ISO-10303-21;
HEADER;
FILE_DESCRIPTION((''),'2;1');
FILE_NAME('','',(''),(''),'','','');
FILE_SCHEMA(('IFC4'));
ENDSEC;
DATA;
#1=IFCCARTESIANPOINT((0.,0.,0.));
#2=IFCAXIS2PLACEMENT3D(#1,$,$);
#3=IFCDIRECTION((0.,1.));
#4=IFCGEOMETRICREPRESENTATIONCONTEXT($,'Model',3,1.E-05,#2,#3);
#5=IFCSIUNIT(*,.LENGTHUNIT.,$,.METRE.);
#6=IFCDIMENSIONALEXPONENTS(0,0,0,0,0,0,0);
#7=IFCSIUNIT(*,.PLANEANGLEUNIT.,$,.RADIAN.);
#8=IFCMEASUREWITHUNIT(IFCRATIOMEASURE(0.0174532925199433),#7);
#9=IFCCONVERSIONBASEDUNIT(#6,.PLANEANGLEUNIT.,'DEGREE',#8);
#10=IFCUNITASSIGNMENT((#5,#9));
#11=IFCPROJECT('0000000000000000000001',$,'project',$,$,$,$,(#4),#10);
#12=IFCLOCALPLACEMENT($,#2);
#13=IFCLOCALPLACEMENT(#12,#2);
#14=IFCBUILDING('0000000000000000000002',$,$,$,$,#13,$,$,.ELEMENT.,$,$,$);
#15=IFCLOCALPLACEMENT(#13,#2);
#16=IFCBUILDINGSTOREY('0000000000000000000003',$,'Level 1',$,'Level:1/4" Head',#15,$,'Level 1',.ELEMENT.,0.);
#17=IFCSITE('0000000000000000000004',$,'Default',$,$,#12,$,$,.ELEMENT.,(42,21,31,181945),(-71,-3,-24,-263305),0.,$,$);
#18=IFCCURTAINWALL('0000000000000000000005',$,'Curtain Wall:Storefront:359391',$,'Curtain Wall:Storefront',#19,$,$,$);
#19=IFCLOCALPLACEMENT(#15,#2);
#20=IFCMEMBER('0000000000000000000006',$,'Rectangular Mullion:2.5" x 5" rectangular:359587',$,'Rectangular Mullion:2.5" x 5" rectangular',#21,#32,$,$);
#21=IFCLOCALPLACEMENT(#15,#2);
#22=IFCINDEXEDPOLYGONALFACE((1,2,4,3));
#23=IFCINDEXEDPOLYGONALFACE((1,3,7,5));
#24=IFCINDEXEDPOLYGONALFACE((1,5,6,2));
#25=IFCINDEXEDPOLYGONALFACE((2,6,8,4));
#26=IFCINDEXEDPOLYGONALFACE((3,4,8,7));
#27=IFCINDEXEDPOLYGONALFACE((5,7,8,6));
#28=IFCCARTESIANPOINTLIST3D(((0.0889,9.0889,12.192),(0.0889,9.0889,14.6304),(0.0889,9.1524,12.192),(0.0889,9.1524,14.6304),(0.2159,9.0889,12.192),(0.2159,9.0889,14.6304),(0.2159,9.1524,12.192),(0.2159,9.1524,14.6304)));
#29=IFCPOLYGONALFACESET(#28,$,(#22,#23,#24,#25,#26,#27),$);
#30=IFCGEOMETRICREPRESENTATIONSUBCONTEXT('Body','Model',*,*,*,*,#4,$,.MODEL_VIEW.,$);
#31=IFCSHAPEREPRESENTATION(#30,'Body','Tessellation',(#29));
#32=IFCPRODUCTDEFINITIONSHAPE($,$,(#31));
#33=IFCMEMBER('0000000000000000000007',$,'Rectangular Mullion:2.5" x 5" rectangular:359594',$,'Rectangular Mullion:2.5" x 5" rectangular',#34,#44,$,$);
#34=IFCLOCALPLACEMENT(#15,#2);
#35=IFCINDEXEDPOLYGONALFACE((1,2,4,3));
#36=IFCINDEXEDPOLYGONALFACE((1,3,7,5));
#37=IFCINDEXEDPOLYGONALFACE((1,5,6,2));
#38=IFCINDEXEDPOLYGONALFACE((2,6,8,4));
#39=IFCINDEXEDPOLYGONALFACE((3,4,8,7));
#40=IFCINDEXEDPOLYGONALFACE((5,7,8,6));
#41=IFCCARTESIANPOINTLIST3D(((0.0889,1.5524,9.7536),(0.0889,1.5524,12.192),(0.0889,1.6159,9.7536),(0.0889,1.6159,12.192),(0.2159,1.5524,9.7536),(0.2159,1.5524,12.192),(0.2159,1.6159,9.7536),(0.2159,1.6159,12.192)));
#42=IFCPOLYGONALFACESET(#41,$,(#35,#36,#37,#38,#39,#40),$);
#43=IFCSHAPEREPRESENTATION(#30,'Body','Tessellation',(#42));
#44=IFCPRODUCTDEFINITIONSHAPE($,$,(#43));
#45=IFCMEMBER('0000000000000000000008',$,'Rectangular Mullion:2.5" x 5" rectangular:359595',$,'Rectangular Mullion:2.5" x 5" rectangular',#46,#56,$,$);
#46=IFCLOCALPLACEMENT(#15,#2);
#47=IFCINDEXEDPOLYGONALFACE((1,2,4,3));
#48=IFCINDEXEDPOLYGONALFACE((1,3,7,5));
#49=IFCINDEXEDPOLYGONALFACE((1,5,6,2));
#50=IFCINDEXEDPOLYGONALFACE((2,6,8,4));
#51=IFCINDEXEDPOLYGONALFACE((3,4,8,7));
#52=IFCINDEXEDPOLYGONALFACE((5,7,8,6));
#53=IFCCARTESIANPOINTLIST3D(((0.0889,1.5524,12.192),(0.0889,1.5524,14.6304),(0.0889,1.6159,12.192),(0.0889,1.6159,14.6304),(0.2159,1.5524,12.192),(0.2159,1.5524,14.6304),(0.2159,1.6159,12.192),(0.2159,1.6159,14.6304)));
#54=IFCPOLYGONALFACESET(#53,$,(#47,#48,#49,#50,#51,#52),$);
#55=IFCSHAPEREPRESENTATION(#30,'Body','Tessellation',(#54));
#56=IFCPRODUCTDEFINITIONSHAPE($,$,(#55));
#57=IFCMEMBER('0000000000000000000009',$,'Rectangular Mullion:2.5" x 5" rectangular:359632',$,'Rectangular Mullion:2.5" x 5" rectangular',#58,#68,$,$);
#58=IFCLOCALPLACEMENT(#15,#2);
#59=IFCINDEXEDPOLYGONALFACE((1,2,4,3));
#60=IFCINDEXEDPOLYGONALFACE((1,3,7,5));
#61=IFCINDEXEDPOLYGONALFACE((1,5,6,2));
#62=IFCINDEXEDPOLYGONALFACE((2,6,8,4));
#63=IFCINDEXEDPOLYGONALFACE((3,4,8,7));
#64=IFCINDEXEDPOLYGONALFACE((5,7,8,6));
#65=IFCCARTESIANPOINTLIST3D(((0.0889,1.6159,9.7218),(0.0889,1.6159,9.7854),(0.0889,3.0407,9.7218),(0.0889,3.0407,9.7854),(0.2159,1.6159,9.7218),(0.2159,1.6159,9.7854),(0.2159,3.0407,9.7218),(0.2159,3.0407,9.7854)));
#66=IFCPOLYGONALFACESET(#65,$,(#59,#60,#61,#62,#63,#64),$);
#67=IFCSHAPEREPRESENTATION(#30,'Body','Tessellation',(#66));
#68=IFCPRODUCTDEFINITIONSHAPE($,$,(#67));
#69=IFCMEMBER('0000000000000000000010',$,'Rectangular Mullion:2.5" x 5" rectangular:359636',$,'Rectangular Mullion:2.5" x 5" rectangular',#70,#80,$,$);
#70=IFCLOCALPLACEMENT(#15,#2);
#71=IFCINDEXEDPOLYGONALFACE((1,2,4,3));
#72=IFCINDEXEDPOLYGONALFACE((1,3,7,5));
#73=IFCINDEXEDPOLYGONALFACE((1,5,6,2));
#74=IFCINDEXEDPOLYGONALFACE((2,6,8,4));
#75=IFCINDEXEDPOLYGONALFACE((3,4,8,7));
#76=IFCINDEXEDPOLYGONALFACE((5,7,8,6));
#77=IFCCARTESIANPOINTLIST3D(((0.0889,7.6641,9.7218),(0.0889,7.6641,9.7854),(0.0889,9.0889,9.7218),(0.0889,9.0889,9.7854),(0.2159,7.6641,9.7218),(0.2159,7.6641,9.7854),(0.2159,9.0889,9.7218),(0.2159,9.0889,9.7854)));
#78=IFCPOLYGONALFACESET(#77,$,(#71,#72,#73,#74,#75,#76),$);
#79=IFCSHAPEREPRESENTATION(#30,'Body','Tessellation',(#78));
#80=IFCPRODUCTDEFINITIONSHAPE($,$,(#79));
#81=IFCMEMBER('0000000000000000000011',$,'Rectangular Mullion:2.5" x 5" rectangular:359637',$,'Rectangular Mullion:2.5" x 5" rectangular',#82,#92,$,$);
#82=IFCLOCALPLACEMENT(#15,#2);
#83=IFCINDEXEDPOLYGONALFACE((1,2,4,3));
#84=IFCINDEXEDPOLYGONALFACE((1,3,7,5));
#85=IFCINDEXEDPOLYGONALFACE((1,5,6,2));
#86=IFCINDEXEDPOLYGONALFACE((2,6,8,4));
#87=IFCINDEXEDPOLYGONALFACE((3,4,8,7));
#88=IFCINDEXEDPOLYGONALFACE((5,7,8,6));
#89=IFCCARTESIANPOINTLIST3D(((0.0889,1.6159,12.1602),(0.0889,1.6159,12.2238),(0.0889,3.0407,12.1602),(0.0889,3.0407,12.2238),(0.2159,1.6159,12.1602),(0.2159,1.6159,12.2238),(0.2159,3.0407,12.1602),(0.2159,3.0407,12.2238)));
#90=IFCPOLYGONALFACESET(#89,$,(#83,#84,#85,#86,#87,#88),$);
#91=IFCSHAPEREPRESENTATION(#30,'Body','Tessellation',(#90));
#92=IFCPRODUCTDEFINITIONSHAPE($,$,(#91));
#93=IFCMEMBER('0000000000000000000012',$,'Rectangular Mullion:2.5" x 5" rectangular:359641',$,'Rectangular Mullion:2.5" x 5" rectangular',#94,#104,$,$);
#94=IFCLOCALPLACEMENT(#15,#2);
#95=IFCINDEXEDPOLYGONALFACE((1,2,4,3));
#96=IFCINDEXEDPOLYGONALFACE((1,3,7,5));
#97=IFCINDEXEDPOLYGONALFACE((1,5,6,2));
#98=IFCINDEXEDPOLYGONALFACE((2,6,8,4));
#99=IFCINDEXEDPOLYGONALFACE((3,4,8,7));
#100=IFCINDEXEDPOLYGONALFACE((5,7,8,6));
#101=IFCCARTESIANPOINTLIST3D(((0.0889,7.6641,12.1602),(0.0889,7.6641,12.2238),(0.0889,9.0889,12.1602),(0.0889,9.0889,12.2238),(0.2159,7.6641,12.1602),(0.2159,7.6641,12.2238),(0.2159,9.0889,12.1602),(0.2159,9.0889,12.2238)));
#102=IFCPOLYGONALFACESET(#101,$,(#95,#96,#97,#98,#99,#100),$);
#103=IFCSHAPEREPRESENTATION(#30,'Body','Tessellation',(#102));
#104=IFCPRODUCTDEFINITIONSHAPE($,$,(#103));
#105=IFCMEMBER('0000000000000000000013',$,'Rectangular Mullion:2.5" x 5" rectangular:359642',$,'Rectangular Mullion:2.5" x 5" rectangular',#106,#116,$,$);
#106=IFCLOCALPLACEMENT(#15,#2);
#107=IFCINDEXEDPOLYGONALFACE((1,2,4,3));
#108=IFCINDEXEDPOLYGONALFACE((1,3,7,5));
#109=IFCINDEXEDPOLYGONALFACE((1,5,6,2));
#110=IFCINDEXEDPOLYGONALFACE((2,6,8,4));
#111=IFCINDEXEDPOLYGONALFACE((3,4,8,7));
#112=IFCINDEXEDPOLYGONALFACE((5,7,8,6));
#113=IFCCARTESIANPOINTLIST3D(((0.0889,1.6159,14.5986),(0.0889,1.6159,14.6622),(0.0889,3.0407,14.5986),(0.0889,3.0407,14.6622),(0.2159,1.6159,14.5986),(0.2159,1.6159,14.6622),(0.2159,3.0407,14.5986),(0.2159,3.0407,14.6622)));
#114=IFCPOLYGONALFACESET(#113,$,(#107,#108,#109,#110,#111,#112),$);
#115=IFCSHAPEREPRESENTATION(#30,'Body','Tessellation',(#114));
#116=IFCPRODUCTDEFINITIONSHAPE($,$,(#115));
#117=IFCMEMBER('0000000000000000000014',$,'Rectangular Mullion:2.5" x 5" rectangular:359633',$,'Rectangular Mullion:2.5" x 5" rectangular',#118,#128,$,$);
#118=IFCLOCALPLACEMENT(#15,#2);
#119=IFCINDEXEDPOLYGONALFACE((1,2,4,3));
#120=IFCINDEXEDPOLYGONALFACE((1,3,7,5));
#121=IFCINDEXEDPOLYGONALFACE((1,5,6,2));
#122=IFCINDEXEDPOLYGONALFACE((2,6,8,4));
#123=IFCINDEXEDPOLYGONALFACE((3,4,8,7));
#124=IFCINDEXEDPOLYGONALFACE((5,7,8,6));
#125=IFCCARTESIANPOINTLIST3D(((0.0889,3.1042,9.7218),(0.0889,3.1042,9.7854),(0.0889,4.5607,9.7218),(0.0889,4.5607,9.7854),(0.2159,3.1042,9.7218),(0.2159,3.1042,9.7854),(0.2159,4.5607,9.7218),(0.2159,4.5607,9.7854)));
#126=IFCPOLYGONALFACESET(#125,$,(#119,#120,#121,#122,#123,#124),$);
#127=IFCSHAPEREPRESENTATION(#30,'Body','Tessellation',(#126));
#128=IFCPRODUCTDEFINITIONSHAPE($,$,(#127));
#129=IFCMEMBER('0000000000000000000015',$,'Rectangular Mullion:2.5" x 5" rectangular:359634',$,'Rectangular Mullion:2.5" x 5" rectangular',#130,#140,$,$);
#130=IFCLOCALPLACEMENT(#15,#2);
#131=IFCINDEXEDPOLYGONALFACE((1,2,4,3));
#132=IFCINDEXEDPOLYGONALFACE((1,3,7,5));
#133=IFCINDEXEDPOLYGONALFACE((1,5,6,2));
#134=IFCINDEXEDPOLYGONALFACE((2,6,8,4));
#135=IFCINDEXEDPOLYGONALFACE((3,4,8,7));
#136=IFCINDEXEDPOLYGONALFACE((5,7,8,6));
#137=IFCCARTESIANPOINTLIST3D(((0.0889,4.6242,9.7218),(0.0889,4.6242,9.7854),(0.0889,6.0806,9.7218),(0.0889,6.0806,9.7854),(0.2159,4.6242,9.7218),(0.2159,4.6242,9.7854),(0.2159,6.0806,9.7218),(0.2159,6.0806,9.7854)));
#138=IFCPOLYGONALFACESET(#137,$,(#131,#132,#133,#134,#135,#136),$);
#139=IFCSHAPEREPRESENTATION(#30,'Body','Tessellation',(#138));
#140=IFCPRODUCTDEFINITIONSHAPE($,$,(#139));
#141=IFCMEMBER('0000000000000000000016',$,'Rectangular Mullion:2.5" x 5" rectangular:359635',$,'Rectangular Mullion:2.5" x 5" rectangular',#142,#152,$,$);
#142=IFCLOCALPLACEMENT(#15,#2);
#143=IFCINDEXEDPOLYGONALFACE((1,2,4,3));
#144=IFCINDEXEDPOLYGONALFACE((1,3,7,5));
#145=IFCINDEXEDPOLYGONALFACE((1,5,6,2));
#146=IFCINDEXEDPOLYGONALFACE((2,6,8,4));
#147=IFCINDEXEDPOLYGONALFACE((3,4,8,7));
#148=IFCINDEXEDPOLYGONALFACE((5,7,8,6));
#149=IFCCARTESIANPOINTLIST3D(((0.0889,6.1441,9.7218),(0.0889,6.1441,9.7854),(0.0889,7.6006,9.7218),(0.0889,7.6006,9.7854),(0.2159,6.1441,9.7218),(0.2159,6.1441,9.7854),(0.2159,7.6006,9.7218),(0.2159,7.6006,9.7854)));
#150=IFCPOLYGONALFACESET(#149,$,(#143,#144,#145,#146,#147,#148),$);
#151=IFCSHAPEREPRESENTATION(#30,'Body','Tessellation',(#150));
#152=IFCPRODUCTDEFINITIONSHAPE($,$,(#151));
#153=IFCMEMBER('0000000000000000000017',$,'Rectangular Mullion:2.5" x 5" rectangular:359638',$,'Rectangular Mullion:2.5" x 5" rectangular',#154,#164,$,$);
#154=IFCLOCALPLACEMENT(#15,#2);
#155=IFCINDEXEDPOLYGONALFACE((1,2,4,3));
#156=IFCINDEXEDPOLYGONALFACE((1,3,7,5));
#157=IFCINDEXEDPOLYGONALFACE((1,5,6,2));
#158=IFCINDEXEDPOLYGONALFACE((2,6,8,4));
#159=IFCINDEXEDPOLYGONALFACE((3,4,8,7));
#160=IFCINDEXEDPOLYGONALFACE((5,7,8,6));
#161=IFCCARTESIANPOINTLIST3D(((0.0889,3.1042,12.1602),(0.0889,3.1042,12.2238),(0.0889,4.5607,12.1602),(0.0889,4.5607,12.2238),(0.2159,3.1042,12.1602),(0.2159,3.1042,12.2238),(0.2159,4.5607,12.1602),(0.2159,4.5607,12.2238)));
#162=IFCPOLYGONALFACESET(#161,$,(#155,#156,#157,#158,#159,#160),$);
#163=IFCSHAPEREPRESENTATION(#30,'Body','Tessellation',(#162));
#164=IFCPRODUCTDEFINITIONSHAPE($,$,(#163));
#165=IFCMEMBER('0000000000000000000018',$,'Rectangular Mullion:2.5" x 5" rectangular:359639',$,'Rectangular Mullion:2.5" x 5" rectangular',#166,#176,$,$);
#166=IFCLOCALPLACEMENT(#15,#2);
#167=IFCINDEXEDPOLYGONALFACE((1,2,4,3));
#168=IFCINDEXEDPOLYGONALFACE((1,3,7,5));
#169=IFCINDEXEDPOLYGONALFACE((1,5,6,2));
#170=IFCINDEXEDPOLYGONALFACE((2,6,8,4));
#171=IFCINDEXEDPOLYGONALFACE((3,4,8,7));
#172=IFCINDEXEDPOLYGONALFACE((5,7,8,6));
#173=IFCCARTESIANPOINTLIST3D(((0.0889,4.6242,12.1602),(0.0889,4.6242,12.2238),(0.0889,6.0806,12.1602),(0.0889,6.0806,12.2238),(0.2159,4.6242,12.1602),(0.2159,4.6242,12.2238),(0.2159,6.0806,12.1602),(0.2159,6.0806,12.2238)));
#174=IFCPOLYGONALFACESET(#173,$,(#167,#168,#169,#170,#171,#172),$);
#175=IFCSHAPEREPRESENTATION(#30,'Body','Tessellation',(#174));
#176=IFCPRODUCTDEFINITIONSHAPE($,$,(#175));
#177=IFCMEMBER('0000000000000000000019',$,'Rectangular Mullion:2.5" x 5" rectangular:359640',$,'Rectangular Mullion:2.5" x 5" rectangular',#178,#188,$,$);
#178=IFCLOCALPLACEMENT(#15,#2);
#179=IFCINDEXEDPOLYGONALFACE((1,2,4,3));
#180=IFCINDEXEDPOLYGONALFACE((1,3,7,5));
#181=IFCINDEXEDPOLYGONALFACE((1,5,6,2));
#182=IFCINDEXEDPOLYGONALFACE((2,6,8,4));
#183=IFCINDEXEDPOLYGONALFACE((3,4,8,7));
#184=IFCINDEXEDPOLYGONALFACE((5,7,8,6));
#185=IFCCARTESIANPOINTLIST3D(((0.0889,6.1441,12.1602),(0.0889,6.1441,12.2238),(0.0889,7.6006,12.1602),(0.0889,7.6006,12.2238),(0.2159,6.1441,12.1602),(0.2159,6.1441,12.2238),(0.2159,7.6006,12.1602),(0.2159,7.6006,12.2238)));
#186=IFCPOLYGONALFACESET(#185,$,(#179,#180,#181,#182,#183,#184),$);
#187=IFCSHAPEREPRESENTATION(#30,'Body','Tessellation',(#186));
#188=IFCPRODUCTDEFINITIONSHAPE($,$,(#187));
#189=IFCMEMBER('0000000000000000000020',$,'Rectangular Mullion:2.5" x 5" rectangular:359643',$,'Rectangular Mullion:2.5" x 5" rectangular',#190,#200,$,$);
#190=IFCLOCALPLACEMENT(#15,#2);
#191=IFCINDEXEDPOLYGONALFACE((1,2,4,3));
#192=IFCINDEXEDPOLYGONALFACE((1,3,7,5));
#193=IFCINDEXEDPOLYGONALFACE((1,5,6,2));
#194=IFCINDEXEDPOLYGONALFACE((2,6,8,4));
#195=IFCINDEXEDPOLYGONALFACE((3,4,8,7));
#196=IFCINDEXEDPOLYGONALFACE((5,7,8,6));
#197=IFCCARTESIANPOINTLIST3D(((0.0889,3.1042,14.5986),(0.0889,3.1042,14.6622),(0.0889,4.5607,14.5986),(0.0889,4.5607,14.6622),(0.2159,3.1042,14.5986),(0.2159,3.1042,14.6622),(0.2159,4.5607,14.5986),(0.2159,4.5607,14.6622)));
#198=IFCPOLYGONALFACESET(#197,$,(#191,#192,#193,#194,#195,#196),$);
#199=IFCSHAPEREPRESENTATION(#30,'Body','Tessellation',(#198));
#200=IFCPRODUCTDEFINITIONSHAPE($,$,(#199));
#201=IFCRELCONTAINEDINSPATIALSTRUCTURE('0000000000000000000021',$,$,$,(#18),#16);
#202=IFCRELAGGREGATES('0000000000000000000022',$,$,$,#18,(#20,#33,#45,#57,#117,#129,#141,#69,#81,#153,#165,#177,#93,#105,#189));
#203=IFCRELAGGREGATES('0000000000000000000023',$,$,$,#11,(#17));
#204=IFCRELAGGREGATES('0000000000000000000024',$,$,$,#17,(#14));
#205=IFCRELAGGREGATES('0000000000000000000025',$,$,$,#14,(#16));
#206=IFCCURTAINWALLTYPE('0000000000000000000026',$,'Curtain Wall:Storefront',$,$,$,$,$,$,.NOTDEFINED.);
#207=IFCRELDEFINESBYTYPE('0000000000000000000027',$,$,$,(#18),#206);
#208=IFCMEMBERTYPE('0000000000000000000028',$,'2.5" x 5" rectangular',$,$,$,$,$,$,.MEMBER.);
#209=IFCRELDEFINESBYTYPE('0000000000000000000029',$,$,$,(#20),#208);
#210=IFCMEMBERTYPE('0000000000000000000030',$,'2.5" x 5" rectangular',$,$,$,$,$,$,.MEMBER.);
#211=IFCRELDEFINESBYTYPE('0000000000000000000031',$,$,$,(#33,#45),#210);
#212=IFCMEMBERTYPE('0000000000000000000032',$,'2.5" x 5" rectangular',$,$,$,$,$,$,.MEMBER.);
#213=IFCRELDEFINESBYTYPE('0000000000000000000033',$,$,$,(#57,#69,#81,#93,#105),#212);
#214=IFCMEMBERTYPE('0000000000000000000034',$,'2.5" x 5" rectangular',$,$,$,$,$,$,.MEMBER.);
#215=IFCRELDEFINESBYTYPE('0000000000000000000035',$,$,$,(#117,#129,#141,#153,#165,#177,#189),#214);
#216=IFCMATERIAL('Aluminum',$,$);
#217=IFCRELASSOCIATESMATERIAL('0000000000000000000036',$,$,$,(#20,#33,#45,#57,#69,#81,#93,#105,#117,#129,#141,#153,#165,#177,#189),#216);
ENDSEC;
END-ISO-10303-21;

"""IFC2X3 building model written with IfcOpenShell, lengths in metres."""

from ifc_helpers import new_model, entity, si_unit, converted_unit, direction, frame, origin, origin_2d_with_axis, place, context, subcontext, project, spatial, rectangle, extrude, source, transform, mapped, material, type_object, type_shapes, element, aggregate, save


model = new_model("IFC2X3")

# Units and contexts
model_context = context("Model", 3, precision=1e-05, world=origin(), true_north=direction((0.0, 1.0)))
body_context = subcontext(model_context, "Body", "Model", "MODEL_VIEW")
ifc_project = project(units=[si_unit("LENGTHUNIT", "METRE"), converted_unit("PLANEANGLEUNIT", "DEGREE", entity("IfcRatioMeasure", 0.0174532925199433), si_unit("PLANEANGLEUNIT", "RADIAN"), dimensions=[0, 0, 0, 0, 0, 0, 0])], contexts=[model_context])

# Site, building, storey
site_placement = place(None, origin())
site = spatial("IfcSite", under=ifc_project, at=site_placement, Name="Default", CompositionType="ELEMENT", RefLatitude=(42, 21, 31, 181945), RefLongitude=(-71, -3, -24, -263305), RefElevation=0.0)
building_placement = place(site_placement, origin())
building = spatial("IfcBuilding", under=site, at=building_placement, CompositionType="ELEMENT")
storey_placement = place(building_placement, origin())
storey = spatial("IfcBuildingStorey", under=building, at=storey_placement, Name="Level 1", ObjectType="Level:1/4\" Head", LongName="Level 1", CompositionType="ELEMENT", Elevation=0.0)

# Curtain wall, members
curtain_wall_type = type_object("IfcCurtainWallType", Name="Curtain Wall:Storefront", PredefinedType="NOTDEFINED")
curtain_wall_placement = place(storey_placement, origin())
curtain_wall = element("IfcCurtainWall", 1, at=curtain_wall_placement, inside=storey, type_object=curtain_wall_type, Name="Curtain Wall:Storefront:359391", ObjectType="Curtain Wall:Storefront")
ifc_material_1 = material(Name="Aluminum")
member_type_1 = type_object("IfcMemberType", Name="2.5\" x 5\" rectangular", PredefinedType="MEMBER")
shared_shape_1 = source(origin(), body_context, "Body", "SweptSolid", [
    extrude(rectangle(XDim=0.127, YDim=0.0635, at=origin_2d_with_axis()), frame((-0.0318, 0.0, -2.4384), z_axis=(0.0, 0.0, 1.0), x_axis=(0.0, -1.0, 0.0)), (0.0, 0.0, 1.0), 2.4384),
])
type_shapes(member_type_1, [shared_shape_1])
member_1_placement = place(storey_placement, frame((0.1524, 9.1524, 12.192), z_axis=(0.0, 0.0, -1.0), x_axis=(0.0, 1.0, 0.0)))
member_1 = element("IfcMember", 2, at=member_1_placement, type_object=member_type_1, material=ifc_material_1, Name="Rectangular Mullion:2.5\" x 5\" rectangular:359587", ObjectType="Rectangular Mullion:2.5\" x 5\" rectangular", context=body_context, shape_type="MappedRepresentation", body=[
    mapped(shared_shape_1, transform((0.0, 0.0, 0.0), scale=1.0)),
])
member_type_2 = type_object("IfcMemberType", Name="2.5\" x 5\" rectangular", PredefinedType="MEMBER")
shared_shape_2 = source(origin(), body_context, "Body", "SweptSolid", [
    extrude(rectangle(XDim=0.127, YDim=0.0635, at=origin_2d_with_axis()), frame((-0.0318, 0.0, -2.4384), z_axis=(0.0, 0.0, 1.0), x_axis=(0.0, -1.0, 0.0)), (0.0, 0.0, 1.0), 2.4384),
])
type_shapes(member_type_2, [shared_shape_2])
member_2_placement = place(storey_placement, frame((0.1524, 1.5524, 12.192), z_axis=(0.0, 0.0, 1.0), x_axis=(0.0, -1.0, 0.0)))
member_2 = element("IfcMember", 3, at=member_2_placement, type_object=member_type_2, material=ifc_material_1, Name="Rectangular Mullion:2.5\" x 5\" rectangular:359594", ObjectType="Rectangular Mullion:2.5\" x 5\" rectangular", context=body_context, shape_type="MappedRepresentation", body=[
    mapped(shared_shape_2, transform((0.0, 0.0, 0.0), scale=1.0)),
])
member_3_placement = place(storey_placement, frame((0.1524, 1.5524, 14.6304), z_axis=(0.0, 0.0, 1.0), x_axis=(0.0, -1.0, 0.0)))
member_3 = element("IfcMember", 4, at=member_3_placement, type_object=member_type_2, material=ifc_material_1, Name="Rectangular Mullion:2.5\" x 5\" rectangular:359595", ObjectType="Rectangular Mullion:2.5\" x 5\" rectangular", context=body_context, shape_type="MappedRepresentation", body=[
    mapped(shared_shape_2, transform((0.0, 0.0, 0.0), scale=1.0)),
])
member_type_3 = type_object("IfcMemberType", Name="2.5\" x 5\" rectangular", PredefinedType="MEMBER")
shared_shape_3 = source(origin(), body_context, "Body", "SweptSolid", [
    extrude(rectangle(XDim=0.127, YDim=0.0635, at=origin_2d_with_axis()), frame((0.0, 0.0, -1.4248), z_axis=(0.0, 0.0, 1.0), x_axis=(0.0, -1.0, 0.0)), (0.0, 0.0, 1.0), 1.4248),
])
type_shapes(member_type_3, [shared_shape_3])
member_4_placement = place(storey_placement, frame((0.1524, 3.0407, 9.7536), z_axis=(0.0, 1.0, 0.0), x_axis=(0.0, 0.0, 1.0)))
member_4 = element("IfcMember", 5, at=member_4_placement, type_object=member_type_3, material=ifc_material_1, Name="Rectangular Mullion:2.5\" x 5\" rectangular:359632", ObjectType="Rectangular Mullion:2.5\" x 5\" rectangular", context=body_context, shape_type="MappedRepresentation", body=[
    mapped(shared_shape_3, transform((0.0, 0.0, 0.0), scale=1.0)),
])
member_5_placement = place(storey_placement, frame((0.1524, 9.0889, 9.7536), z_axis=(0.0, 1.0, 0.0), x_axis=(0.0, 0.0, 1.0)))
member_5 = element("IfcMember", 6, at=member_5_placement, type_object=member_type_3, material=ifc_material_1, Name="Rectangular Mullion:2.5\" x 5\" rectangular:359636", ObjectType="Rectangular Mullion:2.5\" x 5\" rectangular", context=body_context, shape_type="MappedRepresentation", body=[
    mapped(shared_shape_3, transform((0.0, 0.0, 0.0), scale=1.0)),
])
member_6_placement = place(storey_placement, frame((0.1524, 3.0407, 12.192), z_axis=(0.0, 1.0, 0.0), x_axis=(0.0, 0.0, 1.0)))
member_6 = element("IfcMember", 7, at=member_6_placement, type_object=member_type_3, material=ifc_material_1, Name="Rectangular Mullion:2.5\" x 5\" rectangular:359637", ObjectType="Rectangular Mullion:2.5\" x 5\" rectangular", context=body_context, shape_type="MappedRepresentation", body=[
    mapped(shared_shape_3, transform((0.0, 0.0, 0.0), scale=1.0)),
])
member_7_placement = place(storey_placement, frame((0.1524, 9.0889, 12.192), z_axis=(0.0, 1.0, 0.0), x_axis=(0.0, 0.0, 1.0)))
member_7 = element("IfcMember", 8, at=member_7_placement, type_object=member_type_3, material=ifc_material_1, Name="Rectangular Mullion:2.5\" x 5\" rectangular:359641", ObjectType="Rectangular Mullion:2.5\" x 5\" rectangular", context=body_context, shape_type="MappedRepresentation", body=[
    mapped(shared_shape_3, transform((0.0, 0.0, 0.0), scale=1.0)),
])
member_8_placement = place(storey_placement, frame((0.1524, 3.0407, 14.6304), z_axis=(0.0, 1.0, 0.0), x_axis=(0.0, 0.0, 1.0)))
member_8 = element("IfcMember", 9, at=member_8_placement, type_object=member_type_3, material=ifc_material_1, Name="Rectangular Mullion:2.5\" x 5\" rectangular:359642", ObjectType="Rectangular Mullion:2.5\" x 5\" rectangular", context=body_context, shape_type="MappedRepresentation", body=[
    mapped(shared_shape_3, transform((0.0, 0.0, 0.0), scale=1.0)),
])
member_type_4 = type_object("IfcMemberType", Name="2.5\" x 5\" rectangular", PredefinedType="MEMBER")
shared_shape_4 = source(origin(), body_context, "Body", "SweptSolid", [
    extrude(rectangle(XDim=0.127, YDim=0.0635, at=origin_2d_with_axis()), frame((0.0, 0.0, -1.4565), z_axis=(0.0, 0.0, 1.0), x_axis=(0.0, -1.0, 0.0)), (0.0, 0.0, 1.0), 1.4565),
])
type_shapes(member_type_4, [shared_shape_4])
member_9_placement = place(storey_placement, frame((0.1524, 4.5607, 9.7536), z_axis=(0.0, 1.0, 0.0), x_axis=(0.0, 0.0, 1.0)))
member_9 = element("IfcMember", 10, at=member_9_placement, type_object=member_type_4, material=ifc_material_1, Name="Rectangular Mullion:2.5\" x 5\" rectangular:359633", ObjectType="Rectangular Mullion:2.5\" x 5\" rectangular", context=body_context, shape_type="MappedRepresentation", body=[
    mapped(shared_shape_4, transform((0.0, 0.0, 0.0), scale=1.0)),
])
member_10_placement = place(storey_placement, frame((0.1524, 6.0806, 9.7536), z_axis=(0.0, 1.0, 0.0), x_axis=(0.0, 0.0, 1.0)))
member_10 = element("IfcMember", 11, at=member_10_placement, type_object=member_type_4, material=ifc_material_1, Name="Rectangular Mullion:2.5\" x 5\" rectangular:359634", ObjectType="Rectangular Mullion:2.5\" x 5\" rectangular", context=body_context, shape_type="MappedRepresentation", body=[
    mapped(shared_shape_4, transform((0.0, 0.0, 0.0), scale=1.0)),
])
member_11_placement = place(storey_placement, frame((0.1524, 7.6006, 9.7536), z_axis=(0.0, 1.0, 0.0), x_axis=(0.0, 0.0, 1.0)))
member_11 = element("IfcMember", 12, at=member_11_placement, type_object=member_type_4, material=ifc_material_1, Name="Rectangular Mullion:2.5\" x 5\" rectangular:359635", ObjectType="Rectangular Mullion:2.5\" x 5\" rectangular", context=body_context, shape_type="MappedRepresentation", body=[
    mapped(shared_shape_4, transform((0.0, 0.0, 0.0), scale=1.0)),
])
member_12_placement = place(storey_placement, frame((0.1524, 4.5607, 12.192), z_axis=(0.0, 1.0, 0.0), x_axis=(0.0, 0.0, 1.0)))
member_12 = element("IfcMember", 13, at=member_12_placement, type_object=member_type_4, material=ifc_material_1, Name="Rectangular Mullion:2.5\" x 5\" rectangular:359638", ObjectType="Rectangular Mullion:2.5\" x 5\" rectangular", context=body_context, shape_type="MappedRepresentation", body=[
    mapped(shared_shape_4, transform((0.0, 0.0, 0.0), scale=1.0)),
])
member_13_placement = place(storey_placement, frame((0.1524, 6.0806, 12.192), z_axis=(0.0, 1.0, 0.0), x_axis=(0.0, 0.0, 1.0)))
member_13 = element("IfcMember", 14, at=member_13_placement, type_object=member_type_4, material=ifc_material_1, Name="Rectangular Mullion:2.5\" x 5\" rectangular:359639", ObjectType="Rectangular Mullion:2.5\" x 5\" rectangular", context=body_context, shape_type="MappedRepresentation", body=[
    mapped(shared_shape_4, transform((0.0, 0.0, 0.0), scale=1.0)),
])
member_14_placement = place(storey_placement, frame((0.1524, 7.6006, 12.192), z_axis=(0.0, 1.0, 0.0), x_axis=(0.0, 0.0, 1.0)))
member_14 = element("IfcMember", 15, at=member_14_placement, type_object=member_type_4, material=ifc_material_1, Name="Rectangular Mullion:2.5\" x 5\" rectangular:359640", ObjectType="Rectangular Mullion:2.5\" x 5\" rectangular", context=body_context, shape_type="MappedRepresentation", body=[
    mapped(shared_shape_4, transform((0.0, 0.0, 0.0), scale=1.0)),
])
member_15_placement = place(storey_placement, frame((0.1524, 4.5607, 14.6304), z_axis=(0.0, 1.0, 0.0), x_axis=(0.0, 0.0, 1.0)))
member_15 = element("IfcMember", 16, at=member_15_placement, type_object=member_type_4, material=ifc_material_1, Name="Rectangular Mullion:2.5\" x 5\" rectangular:359643", ObjectType="Rectangular Mullion:2.5\" x 5\" rectangular", context=body_context, shape_type="MappedRepresentation", body=[
    mapped(shared_shape_4, transform((0.0, 0.0, 0.0), scale=1.0)),
])
aggregate(curtain_wall, [member_1, member_2, member_3, member_4, member_9, member_10, member_11, member_5, member_6, member_12, member_13, member_14, member_7, member_8, member_15])

save(model, "model.ifc")
